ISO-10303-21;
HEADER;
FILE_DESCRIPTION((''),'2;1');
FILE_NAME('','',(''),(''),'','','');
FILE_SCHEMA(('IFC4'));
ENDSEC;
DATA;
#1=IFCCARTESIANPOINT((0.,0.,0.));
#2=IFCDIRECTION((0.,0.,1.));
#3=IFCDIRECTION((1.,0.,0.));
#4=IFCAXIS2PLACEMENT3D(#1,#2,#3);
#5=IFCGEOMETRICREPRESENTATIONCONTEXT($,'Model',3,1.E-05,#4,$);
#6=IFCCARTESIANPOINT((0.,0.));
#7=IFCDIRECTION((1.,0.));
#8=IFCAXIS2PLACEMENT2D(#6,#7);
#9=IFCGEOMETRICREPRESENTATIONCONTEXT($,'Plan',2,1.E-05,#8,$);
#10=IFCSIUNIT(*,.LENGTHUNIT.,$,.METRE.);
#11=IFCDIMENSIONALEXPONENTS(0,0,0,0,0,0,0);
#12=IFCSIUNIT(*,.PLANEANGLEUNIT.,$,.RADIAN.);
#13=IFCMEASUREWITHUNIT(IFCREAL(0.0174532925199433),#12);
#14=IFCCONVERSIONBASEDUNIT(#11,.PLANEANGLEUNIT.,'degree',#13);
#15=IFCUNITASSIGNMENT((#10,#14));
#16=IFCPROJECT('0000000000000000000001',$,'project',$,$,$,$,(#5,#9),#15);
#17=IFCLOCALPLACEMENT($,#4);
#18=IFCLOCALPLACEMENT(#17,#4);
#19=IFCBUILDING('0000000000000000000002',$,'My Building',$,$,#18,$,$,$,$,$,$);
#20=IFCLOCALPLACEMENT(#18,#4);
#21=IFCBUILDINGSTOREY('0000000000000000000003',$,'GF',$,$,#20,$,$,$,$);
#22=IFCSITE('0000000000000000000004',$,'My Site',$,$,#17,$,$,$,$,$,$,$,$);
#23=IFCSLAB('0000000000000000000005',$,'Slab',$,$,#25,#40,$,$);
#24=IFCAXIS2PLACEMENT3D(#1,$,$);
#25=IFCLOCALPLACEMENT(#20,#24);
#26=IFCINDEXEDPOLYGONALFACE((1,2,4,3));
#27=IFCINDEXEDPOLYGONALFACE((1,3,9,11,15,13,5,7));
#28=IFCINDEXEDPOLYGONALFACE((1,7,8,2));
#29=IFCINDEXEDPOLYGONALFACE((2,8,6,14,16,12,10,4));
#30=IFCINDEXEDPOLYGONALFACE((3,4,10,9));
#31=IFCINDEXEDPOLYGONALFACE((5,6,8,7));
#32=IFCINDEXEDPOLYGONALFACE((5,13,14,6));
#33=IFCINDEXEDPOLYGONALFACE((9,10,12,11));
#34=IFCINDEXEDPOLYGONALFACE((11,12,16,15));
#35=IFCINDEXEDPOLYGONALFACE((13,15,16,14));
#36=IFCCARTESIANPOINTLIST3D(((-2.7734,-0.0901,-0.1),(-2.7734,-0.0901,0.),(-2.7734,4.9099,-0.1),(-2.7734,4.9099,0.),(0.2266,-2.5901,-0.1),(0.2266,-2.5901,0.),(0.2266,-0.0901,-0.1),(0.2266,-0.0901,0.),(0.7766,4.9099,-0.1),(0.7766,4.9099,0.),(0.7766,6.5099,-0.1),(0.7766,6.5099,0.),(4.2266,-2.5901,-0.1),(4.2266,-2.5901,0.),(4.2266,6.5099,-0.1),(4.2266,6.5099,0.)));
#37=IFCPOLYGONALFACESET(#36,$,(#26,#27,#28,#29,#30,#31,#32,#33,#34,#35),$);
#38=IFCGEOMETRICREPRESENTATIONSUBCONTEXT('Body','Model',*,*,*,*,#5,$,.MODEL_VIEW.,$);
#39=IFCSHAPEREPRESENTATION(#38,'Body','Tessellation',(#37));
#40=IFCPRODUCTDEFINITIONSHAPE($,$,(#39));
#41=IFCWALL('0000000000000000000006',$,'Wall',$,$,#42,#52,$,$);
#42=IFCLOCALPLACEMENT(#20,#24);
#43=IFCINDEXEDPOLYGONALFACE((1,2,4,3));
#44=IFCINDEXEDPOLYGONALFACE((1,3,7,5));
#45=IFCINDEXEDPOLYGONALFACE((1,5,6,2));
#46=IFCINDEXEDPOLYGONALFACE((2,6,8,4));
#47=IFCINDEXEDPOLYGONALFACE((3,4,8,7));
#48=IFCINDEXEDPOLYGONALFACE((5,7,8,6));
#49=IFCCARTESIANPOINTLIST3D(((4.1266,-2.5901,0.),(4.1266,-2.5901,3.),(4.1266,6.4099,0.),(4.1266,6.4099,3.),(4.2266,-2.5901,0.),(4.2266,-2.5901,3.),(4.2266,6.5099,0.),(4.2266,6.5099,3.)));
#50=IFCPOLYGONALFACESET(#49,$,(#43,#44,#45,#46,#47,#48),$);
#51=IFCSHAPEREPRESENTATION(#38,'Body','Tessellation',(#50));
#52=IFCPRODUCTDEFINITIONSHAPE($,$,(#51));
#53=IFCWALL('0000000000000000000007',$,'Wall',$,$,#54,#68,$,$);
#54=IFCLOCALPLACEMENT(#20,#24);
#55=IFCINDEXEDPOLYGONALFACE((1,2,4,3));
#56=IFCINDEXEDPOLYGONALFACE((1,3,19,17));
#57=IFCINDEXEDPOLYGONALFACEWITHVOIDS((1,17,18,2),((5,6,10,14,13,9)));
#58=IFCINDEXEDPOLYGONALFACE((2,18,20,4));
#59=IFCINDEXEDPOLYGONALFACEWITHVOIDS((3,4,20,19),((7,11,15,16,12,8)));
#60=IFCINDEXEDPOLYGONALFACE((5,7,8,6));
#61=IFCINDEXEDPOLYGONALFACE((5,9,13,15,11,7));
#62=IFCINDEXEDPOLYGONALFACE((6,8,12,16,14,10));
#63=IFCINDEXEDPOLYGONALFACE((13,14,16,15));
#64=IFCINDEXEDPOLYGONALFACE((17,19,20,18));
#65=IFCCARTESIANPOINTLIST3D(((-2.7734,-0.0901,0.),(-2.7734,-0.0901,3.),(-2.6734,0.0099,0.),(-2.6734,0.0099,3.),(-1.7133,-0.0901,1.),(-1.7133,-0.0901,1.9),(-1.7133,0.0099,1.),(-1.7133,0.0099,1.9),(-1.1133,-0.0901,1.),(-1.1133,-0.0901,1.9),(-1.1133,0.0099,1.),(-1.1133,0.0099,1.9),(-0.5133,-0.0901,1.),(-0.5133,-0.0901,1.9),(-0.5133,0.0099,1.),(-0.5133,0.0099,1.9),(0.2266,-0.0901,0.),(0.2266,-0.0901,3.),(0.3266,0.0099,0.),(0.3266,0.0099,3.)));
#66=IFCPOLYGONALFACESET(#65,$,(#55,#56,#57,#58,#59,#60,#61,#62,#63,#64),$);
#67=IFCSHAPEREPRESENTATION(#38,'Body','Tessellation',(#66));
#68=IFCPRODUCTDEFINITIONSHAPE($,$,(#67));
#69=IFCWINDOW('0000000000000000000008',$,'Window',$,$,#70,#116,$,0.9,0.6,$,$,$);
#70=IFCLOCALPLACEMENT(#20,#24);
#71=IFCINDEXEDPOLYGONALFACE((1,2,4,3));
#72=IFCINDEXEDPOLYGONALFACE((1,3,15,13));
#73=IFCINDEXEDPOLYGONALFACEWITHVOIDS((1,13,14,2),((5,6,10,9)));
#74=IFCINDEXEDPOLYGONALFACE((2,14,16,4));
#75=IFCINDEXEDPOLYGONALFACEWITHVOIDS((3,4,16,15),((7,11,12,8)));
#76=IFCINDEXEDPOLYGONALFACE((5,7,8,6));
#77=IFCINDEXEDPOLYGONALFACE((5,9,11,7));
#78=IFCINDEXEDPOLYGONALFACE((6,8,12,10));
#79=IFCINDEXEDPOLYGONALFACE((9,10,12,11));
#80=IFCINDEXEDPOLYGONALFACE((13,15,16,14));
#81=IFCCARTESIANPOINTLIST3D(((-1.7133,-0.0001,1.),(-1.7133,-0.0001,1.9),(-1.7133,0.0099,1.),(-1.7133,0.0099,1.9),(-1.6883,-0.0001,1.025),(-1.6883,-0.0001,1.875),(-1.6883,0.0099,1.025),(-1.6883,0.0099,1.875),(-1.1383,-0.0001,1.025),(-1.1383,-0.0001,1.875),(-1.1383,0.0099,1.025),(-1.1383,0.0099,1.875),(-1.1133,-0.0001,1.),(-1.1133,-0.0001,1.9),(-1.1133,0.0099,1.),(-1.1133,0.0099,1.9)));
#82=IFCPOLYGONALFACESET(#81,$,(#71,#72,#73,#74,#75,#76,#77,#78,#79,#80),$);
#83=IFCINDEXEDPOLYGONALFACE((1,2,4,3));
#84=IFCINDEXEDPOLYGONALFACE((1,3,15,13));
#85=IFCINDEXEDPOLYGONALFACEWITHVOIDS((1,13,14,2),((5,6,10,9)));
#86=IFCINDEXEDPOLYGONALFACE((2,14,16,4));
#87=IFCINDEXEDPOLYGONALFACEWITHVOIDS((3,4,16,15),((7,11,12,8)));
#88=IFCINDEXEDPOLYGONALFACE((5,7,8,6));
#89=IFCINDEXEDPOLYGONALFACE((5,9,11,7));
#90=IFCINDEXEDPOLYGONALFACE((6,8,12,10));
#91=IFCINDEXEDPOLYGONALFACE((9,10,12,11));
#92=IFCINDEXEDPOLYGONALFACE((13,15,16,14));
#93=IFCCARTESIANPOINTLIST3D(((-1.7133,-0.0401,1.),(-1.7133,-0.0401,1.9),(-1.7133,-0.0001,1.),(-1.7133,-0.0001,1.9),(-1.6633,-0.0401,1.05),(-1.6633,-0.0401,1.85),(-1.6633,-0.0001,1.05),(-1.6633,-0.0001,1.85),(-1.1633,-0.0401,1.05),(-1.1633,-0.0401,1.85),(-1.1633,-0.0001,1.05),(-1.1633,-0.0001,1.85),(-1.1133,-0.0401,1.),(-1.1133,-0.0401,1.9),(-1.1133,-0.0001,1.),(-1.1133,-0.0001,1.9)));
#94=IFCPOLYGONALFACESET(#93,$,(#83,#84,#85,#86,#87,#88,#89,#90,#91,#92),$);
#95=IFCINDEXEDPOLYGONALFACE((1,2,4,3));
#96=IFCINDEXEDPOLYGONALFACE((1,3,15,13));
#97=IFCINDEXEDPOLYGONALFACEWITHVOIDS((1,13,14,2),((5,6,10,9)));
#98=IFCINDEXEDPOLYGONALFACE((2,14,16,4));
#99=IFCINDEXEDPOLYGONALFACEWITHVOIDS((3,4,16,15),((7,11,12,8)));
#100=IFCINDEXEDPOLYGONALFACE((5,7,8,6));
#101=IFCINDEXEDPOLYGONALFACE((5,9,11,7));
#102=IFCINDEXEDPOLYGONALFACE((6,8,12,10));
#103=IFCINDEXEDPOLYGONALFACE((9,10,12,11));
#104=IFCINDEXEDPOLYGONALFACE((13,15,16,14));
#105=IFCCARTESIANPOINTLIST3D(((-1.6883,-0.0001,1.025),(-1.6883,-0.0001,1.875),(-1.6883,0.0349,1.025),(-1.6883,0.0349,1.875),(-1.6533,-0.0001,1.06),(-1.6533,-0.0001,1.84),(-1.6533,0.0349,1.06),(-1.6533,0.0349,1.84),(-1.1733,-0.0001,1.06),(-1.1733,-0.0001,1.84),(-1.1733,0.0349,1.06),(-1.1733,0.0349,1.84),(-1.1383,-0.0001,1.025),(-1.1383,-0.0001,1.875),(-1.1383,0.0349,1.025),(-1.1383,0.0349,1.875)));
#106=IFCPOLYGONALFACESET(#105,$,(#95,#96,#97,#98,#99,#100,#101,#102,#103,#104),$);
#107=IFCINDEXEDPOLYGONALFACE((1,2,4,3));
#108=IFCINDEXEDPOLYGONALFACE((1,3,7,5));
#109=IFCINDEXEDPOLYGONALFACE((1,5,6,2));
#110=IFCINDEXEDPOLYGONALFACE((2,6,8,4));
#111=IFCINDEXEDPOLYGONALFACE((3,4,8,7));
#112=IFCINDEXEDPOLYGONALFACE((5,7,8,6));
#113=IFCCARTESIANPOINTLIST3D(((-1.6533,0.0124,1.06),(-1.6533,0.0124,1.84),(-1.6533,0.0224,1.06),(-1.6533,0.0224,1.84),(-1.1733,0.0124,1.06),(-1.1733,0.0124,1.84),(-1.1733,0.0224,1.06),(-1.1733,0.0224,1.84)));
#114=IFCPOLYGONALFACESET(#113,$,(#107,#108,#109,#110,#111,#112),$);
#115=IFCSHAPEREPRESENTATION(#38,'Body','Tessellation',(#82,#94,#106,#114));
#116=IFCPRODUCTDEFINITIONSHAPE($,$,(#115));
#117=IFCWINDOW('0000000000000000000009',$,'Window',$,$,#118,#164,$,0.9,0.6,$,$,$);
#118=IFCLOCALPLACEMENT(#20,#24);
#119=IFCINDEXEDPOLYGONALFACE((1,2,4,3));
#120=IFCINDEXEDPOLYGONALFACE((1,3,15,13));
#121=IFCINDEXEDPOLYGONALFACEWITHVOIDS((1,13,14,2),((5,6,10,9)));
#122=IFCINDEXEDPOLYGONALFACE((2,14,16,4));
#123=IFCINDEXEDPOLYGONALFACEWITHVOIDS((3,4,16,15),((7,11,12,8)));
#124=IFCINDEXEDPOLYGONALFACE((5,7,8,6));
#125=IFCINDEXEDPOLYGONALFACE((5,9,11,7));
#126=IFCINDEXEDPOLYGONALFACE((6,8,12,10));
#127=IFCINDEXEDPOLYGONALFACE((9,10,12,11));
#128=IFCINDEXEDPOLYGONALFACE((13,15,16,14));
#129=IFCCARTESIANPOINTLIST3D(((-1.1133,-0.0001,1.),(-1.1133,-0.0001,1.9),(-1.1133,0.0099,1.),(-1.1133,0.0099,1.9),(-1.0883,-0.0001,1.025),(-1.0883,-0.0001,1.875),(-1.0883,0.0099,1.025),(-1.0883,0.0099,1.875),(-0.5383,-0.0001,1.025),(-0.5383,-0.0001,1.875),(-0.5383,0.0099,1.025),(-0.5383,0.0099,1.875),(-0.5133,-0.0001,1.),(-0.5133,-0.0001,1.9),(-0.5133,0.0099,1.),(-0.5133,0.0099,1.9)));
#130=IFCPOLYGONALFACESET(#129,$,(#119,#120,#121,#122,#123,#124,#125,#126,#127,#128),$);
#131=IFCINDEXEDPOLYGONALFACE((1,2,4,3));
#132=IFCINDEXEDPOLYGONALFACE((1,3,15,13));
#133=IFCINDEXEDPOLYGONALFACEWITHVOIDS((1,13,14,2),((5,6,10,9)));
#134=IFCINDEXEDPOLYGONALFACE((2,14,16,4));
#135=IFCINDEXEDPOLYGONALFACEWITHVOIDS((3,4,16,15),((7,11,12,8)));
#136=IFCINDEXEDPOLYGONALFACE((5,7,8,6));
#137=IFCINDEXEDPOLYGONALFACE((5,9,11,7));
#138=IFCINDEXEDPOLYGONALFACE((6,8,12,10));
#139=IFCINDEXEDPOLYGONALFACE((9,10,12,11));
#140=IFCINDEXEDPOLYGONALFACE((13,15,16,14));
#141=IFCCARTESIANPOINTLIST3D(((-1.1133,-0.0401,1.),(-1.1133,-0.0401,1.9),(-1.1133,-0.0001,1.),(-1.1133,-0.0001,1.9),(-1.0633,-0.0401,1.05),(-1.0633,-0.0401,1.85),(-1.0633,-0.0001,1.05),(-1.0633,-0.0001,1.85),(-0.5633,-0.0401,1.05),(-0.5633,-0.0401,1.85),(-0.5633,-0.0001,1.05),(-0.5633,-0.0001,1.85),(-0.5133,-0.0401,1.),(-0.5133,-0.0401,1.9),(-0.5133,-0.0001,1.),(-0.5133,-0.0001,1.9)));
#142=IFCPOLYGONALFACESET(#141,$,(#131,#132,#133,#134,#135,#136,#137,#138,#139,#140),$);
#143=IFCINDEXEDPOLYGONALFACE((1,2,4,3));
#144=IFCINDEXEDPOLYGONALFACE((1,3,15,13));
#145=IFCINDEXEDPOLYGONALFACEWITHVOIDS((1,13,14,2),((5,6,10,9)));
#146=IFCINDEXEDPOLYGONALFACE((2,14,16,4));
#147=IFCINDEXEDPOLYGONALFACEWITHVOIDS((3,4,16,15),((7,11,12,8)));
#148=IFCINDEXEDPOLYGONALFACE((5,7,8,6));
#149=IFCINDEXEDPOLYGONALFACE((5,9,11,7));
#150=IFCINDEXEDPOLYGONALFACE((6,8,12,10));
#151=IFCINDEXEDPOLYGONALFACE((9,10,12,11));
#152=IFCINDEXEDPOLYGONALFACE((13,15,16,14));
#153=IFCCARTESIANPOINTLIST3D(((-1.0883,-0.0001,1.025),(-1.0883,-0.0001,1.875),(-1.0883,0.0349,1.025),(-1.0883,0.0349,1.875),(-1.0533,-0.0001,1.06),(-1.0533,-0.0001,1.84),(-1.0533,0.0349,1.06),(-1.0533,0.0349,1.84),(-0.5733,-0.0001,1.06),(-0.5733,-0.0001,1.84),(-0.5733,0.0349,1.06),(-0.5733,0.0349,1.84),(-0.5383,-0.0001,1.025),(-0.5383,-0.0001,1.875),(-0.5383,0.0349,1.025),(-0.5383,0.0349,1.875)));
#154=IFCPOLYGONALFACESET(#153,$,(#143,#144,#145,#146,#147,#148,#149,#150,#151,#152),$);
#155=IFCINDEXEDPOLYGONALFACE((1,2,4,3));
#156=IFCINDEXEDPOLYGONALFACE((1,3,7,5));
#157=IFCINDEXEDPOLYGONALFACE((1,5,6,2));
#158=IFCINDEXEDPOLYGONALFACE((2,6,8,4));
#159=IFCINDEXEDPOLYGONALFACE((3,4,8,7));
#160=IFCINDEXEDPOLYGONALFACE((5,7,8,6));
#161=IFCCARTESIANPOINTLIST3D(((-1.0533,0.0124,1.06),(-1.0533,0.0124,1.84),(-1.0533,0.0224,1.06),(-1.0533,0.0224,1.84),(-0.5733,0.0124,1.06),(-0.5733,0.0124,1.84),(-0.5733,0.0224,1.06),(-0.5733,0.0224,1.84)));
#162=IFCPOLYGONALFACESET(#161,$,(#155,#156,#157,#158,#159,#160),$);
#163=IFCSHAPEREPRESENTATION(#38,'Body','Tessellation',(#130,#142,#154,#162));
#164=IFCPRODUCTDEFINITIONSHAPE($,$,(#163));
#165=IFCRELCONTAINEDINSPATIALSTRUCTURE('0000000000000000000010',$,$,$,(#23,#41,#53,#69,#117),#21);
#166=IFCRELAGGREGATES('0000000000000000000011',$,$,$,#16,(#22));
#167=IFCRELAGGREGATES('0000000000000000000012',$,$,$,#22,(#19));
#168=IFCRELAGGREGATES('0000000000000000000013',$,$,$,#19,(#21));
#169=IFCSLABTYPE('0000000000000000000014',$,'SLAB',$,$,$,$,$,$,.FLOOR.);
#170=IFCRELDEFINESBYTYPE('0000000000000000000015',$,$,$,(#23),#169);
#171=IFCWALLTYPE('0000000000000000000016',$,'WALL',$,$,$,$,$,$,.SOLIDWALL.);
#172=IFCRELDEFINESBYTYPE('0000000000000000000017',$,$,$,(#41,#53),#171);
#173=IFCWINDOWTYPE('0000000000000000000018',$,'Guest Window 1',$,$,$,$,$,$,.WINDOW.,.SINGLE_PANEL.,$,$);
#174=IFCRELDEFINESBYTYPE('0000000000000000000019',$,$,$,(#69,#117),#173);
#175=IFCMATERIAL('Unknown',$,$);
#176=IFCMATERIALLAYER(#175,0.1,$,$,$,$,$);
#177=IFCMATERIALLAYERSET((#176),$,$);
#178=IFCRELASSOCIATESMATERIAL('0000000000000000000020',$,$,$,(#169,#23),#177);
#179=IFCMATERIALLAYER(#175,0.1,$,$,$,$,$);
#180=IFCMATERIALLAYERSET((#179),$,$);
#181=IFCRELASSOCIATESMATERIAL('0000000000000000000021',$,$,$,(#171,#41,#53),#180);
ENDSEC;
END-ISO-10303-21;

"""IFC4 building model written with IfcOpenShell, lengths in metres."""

from ifc_helpers import new_model, entity, si_unit, converted_unit, frame, origin_with_axes, origin_2d_with_axis, place, context, subcontext, project, spatial, line, indexed_curve, outline, extrude, shape, source, transform, mapped, material, layer, layer_set, layer_usage, type_object, type_shapes, element, fill, save


model = new_model("IFC4")

# Units and contexts
model_context = context("Model", 3, precision=1e-05, world=origin_with_axes())
plan_context = context("Plan", 2, precision=1e-05, world=origin_2d_with_axis())
body_context_1 = subcontext(model_context, "Body", "Model", "MODEL_VIEW")
body_context_2 = subcontext(plan_context, "Body", "Plan", "PLAN_VIEW")
ifc_project = project(units=[si_unit("LENGTHUNIT", "METRE"), converted_unit("PLANEANGLEUNIT", "degree", entity("IfcReal", 0.0174532925199433), si_unit("PLANEANGLEUNIT", "RADIAN"), dimensions=[0, 0, 0, 0, 0, 0, 0])], contexts=[model_context, plan_context])

# Site, building, storey
site_placement = place(None, origin_with_axes())
site = spatial("IfcSite", under=ifc_project, at=site_placement, Name="My Site")
building_placement = place(site_placement, origin_with_axes())
building = spatial("IfcBuilding", under=site, at=building_placement, Name="My Building")
storey_placement = place(building_placement, origin_with_axes())
storey = spatial("IfcBuildingStorey", under=building, at=storey_placement, Name="GF")

# Slab
ifc_material = material(Name="Unknown")
ifc_layer_1 = layer(ifc_material, 0.1)
ifc_layer_set_1 = layer_set([ifc_layer_1])
ifc_layer_usage_1 = layer_usage(ifc_layer_set_1, "AXIS3", "POSITIVE", -0.1)
slab_type = type_object("IfcSlabType", Name="SLAB", PredefinedType="FLOOR", material=ifc_layer_set_1)
slab_placement = place(storey_placement, frame((4.2266, -2.5901, 0.0), z_axis=(0.0, 0.0, 1.0), x_axis=(1.0, 0.0, 0.0)))
element("IfcSlab", 1, at=slab_placement, inside=storey, type_object=slab_type, material=ifc_layer_usage_1, Name="Slab", context=body_context_1, shape_type="SweptSolid", body=[
    extrude(outline(indexed_curve([(0.0, 0.0), (0.0, 9.1), (-3.45, 9.1), (-3.45, 7.5), (-7.0, 7.5), (-7.0, 2.5), (-4.0, 2.5), (-4.0, 0.0), (0.0, 0.0)])), frame((0.0, 0.0, -0.1), z_axis=(0.0, 0.0, 1.0), x_axis=(1.0, 0.0, 0.0)), (0.0, 0.0, 1.0), 0.1),
])

# Shared definitions
ifc_layer_2 = layer(ifc_material, 0.1)
ifc_layer_set_2 = layer_set([ifc_layer_2])
wall_type = type_object("IfcWallType", Name="WALL", PredefinedType="SOLIDWALL", material=ifc_layer_set_2)

# Wall
ifc_layer_usage_2 = layer_usage(ifc_layer_set_2, "AXIS2", "POSITIVE", 0.0)
wall_1_placement = place(storey_placement, frame((4.2266, -2.5901, 0.0), z_axis=(0.0, 0.0, 1.0), x_axis=(0.0, 1.0, 0.0)))
element("IfcWall", 2, at=wall_1_placement, inside=storey, type_object=wall_type, material=ifc_layer_usage_2, Name="Wall", context=body_context_1, shape_type="SweptSolid", body=[
    extrude(outline(indexed_curve([(0.0, 0.0), (0.0, 0.1), (9.0, 0.1), (9.1, 0.0)], segments=[line(1, 2, 3, 4, 1)])), origin_with_axes(), (0.0, 0.0, 1.0), 3.0),
])

# Wall, openings, windows
ifc_layer_usage_3 = layer_usage(ifc_layer_set_2, "AXIS2", "POSITIVE", 0.0)
wall_2_placement = place(storey_placement, frame((-2.7734, -0.0901, 0.0), z_axis=(0.0, 0.0, 1.0), x_axis=(1.0, 0.0, 0.0)))
wall_2 = element("IfcWall", 3, at=wall_2_placement, inside=storey, type_object=wall_type, material=ifc_layer_usage_3, Name="Wall", context=body_context_1, shape_type="SweptSolid", body=[
    extrude(outline(indexed_curve([(0.0, 0.0), (0.1, 0.1), (3.1, 0.1), (3.0, 0.0)], segments=[line(1, 2, 3, 4, 1)])), origin_with_axes(), (0.0, 0.0, 1.0), 3.0),
])
shared_shape_1 = source(origin_with_axes(), body_context_1, "Body", "SweptSolid", [
    extrude(outline(indexed_curve([(0.0, 0.0), (0.6, 0.0), (0.6, 0.9), (0.0, 0.9)], segments=[line(1, 2, 3, 4, 1)])), frame((0.0, -0.6, 0.0), z_axis=(0.0, -1.0, 0.0), x_axis=(1.0, 0.0, 0.0)), (0.0, 0.0, -1.0), 1.2),
])
opening_1_placement = place(wall_2_placement, frame((1.0601, 0.0, 1.0), z_axis=(0.0, 0.0, 1.0), x_axis=(1.0, 0.0, 0.0)))
opening_1 = element("IfcOpeningElement", 4, at=opening_1_placement, cuts=wall_2, PredefinedType="OPENING", context=body_context_1, shape_type="MappedRepresentation", body=[
    mapped(shared_shape_1, transform((0.0, 0.0, 0.0), x_axis=(1.0, 0.0, 0.0), y_axis=(0.0, 1.0, 0.0), z_axis=(0.0, 0.0, 1.0), scale=1.0)),
])
opening_2_placement = place(wall_2_placement, frame((1.6601, 0.0, 1.0), z_axis=(0.0, 0.0, 1.0), x_axis=(1.0, 0.0, 0.0)))
opening_2 = element("IfcOpeningElement", 5, at=opening_2_placement, cuts=wall_2, PredefinedType="OPENING", context=body_context_1, shape_type="MappedRepresentation", body=[
    mapped(shared_shape_1, transform((0.0, 0.0, 0.0), x_axis=(1.0, 0.0, 0.0), y_axis=(0.0, 1.0, 0.0), z_axis=(0.0, 0.0, 1.0), scale=1.0)),
])
window_type_1 = type_object("IfcWindowType", Name="Guest Window 1", PartitioningType="SINGLE_PANEL", PredefinedType="WINDOW")
shared_shape_2 = source(origin_with_axes(), body_context_1, "Body", "SweptSolid", [
    extrude(outline(indexed_curve([(0.0, 0.0), (0.6, 0.0), (0.6, 0.9), (0.0, 0.9)], segments=[line(1, 2, 3, 4, 1)]), holes=[indexed_curve([(0.025, 0.025), (0.575, 0.025), (0.575, 0.875), (0.025, 0.875)], segments=[line(1, 2, 3, 4, 1)])]), frame((0.0, 0.09, 0.0), z_axis=(0.0, -1.0, 0.0), x_axis=(1.0, 0.0, 0.0)), (0.0, 0.0, -1.0), 0.01),
    extrude(outline(indexed_curve([(0.0, 0.0), (0.6, 0.0), (0.6, 0.9), (0.0, 0.9)], segments=[line(1, 2, 3, 4, 1)]), holes=[indexed_curve([(0.05, 0.05), (0.55, 0.05), (0.55, 0.85), (0.05, 0.85)], segments=[line(1, 2, 3, 4, 1)])]), frame((0.0, 0.05, 0.0), z_axis=(0.0, -1.0, 0.0), x_axis=(1.0, 0.0, 0.0)), (0.0, 0.0, -1.0), 0.04),
    extrude(outline(indexed_curve([(0.0, 0.0), (0.55, 0.0), (0.55, 0.85), (0.0, 0.85)], segments=[line(1, 2, 3, 4, 1)]), holes=[indexed_curve([(0.035, 0.035), (0.515, 0.035), (0.515, 0.815), (0.035, 0.815)], segments=[line(1, 2, 3, 4, 1)])]), frame((0.025, 0.09, 0.025), z_axis=(0.0, -1.0, 0.0), x_axis=(1.0, 0.0, 0.0)), (0.0, 0.0, -1.0), 0.035),
    extrude(outline(indexed_curve([(0.035, 0.035), (0.515, 0.035), (0.515, 0.815), (0.035, 0.815)], segments=[line(1, 2, 3, 4, 1)])), frame((0.025, 0.1025, 0.025), z_axis=(0.0, -1.0, 0.0), x_axis=(1.0, 0.0, 0.0)), (0.0, 0.0, -1.0), 0.01),
])
shared_shape_3 = source(origin_with_axes(), body_context_2, "Body", "Curve2D", [
    entity("IfcIndexedPolyCurve", entity("IfcCartesianPointList2D", [[0.05, 0.05], [0.55, 0.05]])),
    entity("IfcIndexedPolyCurve", entity("IfcCartesianPointList2D", [[0.0, 0.1], [0.025, 0.1], [0.025, 0.09], [0.05, 0.09], [0.05, 0.05], [0.0, 0.05]]), [entity("IfcLineIndex", [1, 2, 3, 4, 5, 6, 1])]),
    entity("IfcIndexedPolyCurve", entity("IfcCartesianPointList2D", [[0.6, 0.1], [0.575, 0.1], [0.575, 0.09], [0.55, 0.09], [0.55, 0.05], [0.6, 0.05]]), [entity("IfcLineIndex", [1, 2, 3, 4, 5, 6, 1])]),
    entity("IfcIndexedPolyCurve", entity("IfcCartesianPointList2D", [[0.025, 0.09], [0.06, 0.09], [0.06, 0.125], [0.025, 0.125]]), [entity("IfcLineIndex", [1, 2, 3, 4, 1])]),
    entity("IfcIndexedPolyCurve", entity("IfcCartesianPointList2D", [[0.575, 0.09], [0.54, 0.09], [0.54, 0.125], [0.575, 0.125]]), [entity("IfcLineIndex", [1, 2, 3, 4, 1])]),
    entity("IfcIndexedPolyCurve", entity("IfcCartesianPointList2D", [[0.06, 0.09], [0.54, 0.09]])),
    entity("IfcIndexedPolyCurve", entity("IfcCartesianPointList2D", [[0.06, 0.125], [0.54, 0.125]])),
    entity("IfcIndexedPolyCurve", entity("IfcCartesianPointList2D", [[0.06, 0.1075], [0.54, 0.1075]])),
])
type_shapes(window_type_1, [shared_shape_2, shared_shape_3])
window_1_placement = place(opening_1_placement, origin_with_axes())
window_1 = element("IfcWindow", 6, at=window_1_placement, inside=storey, type_object=window_type_1, Name="Window", OverallHeight=0.9, OverallWidth=0.6, shapes=[
    shape(body_context_1, "Body", "MappedRepresentation", [mapped(shared_shape_2, transform((0.0, 0.0, 0.0), x_axis=(1.0, 0.0, 0.0), y_axis=(0.0, 1.0, 0.0), z_axis=(0.0, 0.0, 1.0), scale=1.0))]),
    shape(body_context_2, "Body", "MappedRepresentation", [mapped(shared_shape_3, transform((0.0, 0.0, 0.0), x_axis=(1.0, 0.0, 0.0), y_axis=(0.0, 1.0, 0.0), z_axis=(0.0, 0.0, 1.0), scale=1.0))]),
])
fill(opening_1, window_1)
window_2_placement = place(opening_2_placement, origin_with_axes())
window_2 = element("IfcWindow", 7, at=window_2_placement, inside=storey, type_object=window_type_1, Name="Window", OverallHeight=0.9, OverallWidth=0.6, shapes=[
    shape(body_context_1, "Body", "MappedRepresentation", [mapped(shared_shape_2, transform((0.0, 0.0, 0.0), x_axis=(1.0, 0.0, 0.0), y_axis=(0.0, 1.0, 0.0), z_axis=(0.0, 0.0, 1.0), scale=1.0))]),
    shape(body_context_2, "Body", "MappedRepresentation", [mapped(shared_shape_3, transform((0.0, 0.0, 0.0), x_axis=(1.0, 0.0, 0.0), y_axis=(0.0, 1.0, 0.0), z_axis=(0.0, 0.0, 1.0), scale=1.0))]),
])
fill(opening_2, window_2)

save(model, "model.ifc")
